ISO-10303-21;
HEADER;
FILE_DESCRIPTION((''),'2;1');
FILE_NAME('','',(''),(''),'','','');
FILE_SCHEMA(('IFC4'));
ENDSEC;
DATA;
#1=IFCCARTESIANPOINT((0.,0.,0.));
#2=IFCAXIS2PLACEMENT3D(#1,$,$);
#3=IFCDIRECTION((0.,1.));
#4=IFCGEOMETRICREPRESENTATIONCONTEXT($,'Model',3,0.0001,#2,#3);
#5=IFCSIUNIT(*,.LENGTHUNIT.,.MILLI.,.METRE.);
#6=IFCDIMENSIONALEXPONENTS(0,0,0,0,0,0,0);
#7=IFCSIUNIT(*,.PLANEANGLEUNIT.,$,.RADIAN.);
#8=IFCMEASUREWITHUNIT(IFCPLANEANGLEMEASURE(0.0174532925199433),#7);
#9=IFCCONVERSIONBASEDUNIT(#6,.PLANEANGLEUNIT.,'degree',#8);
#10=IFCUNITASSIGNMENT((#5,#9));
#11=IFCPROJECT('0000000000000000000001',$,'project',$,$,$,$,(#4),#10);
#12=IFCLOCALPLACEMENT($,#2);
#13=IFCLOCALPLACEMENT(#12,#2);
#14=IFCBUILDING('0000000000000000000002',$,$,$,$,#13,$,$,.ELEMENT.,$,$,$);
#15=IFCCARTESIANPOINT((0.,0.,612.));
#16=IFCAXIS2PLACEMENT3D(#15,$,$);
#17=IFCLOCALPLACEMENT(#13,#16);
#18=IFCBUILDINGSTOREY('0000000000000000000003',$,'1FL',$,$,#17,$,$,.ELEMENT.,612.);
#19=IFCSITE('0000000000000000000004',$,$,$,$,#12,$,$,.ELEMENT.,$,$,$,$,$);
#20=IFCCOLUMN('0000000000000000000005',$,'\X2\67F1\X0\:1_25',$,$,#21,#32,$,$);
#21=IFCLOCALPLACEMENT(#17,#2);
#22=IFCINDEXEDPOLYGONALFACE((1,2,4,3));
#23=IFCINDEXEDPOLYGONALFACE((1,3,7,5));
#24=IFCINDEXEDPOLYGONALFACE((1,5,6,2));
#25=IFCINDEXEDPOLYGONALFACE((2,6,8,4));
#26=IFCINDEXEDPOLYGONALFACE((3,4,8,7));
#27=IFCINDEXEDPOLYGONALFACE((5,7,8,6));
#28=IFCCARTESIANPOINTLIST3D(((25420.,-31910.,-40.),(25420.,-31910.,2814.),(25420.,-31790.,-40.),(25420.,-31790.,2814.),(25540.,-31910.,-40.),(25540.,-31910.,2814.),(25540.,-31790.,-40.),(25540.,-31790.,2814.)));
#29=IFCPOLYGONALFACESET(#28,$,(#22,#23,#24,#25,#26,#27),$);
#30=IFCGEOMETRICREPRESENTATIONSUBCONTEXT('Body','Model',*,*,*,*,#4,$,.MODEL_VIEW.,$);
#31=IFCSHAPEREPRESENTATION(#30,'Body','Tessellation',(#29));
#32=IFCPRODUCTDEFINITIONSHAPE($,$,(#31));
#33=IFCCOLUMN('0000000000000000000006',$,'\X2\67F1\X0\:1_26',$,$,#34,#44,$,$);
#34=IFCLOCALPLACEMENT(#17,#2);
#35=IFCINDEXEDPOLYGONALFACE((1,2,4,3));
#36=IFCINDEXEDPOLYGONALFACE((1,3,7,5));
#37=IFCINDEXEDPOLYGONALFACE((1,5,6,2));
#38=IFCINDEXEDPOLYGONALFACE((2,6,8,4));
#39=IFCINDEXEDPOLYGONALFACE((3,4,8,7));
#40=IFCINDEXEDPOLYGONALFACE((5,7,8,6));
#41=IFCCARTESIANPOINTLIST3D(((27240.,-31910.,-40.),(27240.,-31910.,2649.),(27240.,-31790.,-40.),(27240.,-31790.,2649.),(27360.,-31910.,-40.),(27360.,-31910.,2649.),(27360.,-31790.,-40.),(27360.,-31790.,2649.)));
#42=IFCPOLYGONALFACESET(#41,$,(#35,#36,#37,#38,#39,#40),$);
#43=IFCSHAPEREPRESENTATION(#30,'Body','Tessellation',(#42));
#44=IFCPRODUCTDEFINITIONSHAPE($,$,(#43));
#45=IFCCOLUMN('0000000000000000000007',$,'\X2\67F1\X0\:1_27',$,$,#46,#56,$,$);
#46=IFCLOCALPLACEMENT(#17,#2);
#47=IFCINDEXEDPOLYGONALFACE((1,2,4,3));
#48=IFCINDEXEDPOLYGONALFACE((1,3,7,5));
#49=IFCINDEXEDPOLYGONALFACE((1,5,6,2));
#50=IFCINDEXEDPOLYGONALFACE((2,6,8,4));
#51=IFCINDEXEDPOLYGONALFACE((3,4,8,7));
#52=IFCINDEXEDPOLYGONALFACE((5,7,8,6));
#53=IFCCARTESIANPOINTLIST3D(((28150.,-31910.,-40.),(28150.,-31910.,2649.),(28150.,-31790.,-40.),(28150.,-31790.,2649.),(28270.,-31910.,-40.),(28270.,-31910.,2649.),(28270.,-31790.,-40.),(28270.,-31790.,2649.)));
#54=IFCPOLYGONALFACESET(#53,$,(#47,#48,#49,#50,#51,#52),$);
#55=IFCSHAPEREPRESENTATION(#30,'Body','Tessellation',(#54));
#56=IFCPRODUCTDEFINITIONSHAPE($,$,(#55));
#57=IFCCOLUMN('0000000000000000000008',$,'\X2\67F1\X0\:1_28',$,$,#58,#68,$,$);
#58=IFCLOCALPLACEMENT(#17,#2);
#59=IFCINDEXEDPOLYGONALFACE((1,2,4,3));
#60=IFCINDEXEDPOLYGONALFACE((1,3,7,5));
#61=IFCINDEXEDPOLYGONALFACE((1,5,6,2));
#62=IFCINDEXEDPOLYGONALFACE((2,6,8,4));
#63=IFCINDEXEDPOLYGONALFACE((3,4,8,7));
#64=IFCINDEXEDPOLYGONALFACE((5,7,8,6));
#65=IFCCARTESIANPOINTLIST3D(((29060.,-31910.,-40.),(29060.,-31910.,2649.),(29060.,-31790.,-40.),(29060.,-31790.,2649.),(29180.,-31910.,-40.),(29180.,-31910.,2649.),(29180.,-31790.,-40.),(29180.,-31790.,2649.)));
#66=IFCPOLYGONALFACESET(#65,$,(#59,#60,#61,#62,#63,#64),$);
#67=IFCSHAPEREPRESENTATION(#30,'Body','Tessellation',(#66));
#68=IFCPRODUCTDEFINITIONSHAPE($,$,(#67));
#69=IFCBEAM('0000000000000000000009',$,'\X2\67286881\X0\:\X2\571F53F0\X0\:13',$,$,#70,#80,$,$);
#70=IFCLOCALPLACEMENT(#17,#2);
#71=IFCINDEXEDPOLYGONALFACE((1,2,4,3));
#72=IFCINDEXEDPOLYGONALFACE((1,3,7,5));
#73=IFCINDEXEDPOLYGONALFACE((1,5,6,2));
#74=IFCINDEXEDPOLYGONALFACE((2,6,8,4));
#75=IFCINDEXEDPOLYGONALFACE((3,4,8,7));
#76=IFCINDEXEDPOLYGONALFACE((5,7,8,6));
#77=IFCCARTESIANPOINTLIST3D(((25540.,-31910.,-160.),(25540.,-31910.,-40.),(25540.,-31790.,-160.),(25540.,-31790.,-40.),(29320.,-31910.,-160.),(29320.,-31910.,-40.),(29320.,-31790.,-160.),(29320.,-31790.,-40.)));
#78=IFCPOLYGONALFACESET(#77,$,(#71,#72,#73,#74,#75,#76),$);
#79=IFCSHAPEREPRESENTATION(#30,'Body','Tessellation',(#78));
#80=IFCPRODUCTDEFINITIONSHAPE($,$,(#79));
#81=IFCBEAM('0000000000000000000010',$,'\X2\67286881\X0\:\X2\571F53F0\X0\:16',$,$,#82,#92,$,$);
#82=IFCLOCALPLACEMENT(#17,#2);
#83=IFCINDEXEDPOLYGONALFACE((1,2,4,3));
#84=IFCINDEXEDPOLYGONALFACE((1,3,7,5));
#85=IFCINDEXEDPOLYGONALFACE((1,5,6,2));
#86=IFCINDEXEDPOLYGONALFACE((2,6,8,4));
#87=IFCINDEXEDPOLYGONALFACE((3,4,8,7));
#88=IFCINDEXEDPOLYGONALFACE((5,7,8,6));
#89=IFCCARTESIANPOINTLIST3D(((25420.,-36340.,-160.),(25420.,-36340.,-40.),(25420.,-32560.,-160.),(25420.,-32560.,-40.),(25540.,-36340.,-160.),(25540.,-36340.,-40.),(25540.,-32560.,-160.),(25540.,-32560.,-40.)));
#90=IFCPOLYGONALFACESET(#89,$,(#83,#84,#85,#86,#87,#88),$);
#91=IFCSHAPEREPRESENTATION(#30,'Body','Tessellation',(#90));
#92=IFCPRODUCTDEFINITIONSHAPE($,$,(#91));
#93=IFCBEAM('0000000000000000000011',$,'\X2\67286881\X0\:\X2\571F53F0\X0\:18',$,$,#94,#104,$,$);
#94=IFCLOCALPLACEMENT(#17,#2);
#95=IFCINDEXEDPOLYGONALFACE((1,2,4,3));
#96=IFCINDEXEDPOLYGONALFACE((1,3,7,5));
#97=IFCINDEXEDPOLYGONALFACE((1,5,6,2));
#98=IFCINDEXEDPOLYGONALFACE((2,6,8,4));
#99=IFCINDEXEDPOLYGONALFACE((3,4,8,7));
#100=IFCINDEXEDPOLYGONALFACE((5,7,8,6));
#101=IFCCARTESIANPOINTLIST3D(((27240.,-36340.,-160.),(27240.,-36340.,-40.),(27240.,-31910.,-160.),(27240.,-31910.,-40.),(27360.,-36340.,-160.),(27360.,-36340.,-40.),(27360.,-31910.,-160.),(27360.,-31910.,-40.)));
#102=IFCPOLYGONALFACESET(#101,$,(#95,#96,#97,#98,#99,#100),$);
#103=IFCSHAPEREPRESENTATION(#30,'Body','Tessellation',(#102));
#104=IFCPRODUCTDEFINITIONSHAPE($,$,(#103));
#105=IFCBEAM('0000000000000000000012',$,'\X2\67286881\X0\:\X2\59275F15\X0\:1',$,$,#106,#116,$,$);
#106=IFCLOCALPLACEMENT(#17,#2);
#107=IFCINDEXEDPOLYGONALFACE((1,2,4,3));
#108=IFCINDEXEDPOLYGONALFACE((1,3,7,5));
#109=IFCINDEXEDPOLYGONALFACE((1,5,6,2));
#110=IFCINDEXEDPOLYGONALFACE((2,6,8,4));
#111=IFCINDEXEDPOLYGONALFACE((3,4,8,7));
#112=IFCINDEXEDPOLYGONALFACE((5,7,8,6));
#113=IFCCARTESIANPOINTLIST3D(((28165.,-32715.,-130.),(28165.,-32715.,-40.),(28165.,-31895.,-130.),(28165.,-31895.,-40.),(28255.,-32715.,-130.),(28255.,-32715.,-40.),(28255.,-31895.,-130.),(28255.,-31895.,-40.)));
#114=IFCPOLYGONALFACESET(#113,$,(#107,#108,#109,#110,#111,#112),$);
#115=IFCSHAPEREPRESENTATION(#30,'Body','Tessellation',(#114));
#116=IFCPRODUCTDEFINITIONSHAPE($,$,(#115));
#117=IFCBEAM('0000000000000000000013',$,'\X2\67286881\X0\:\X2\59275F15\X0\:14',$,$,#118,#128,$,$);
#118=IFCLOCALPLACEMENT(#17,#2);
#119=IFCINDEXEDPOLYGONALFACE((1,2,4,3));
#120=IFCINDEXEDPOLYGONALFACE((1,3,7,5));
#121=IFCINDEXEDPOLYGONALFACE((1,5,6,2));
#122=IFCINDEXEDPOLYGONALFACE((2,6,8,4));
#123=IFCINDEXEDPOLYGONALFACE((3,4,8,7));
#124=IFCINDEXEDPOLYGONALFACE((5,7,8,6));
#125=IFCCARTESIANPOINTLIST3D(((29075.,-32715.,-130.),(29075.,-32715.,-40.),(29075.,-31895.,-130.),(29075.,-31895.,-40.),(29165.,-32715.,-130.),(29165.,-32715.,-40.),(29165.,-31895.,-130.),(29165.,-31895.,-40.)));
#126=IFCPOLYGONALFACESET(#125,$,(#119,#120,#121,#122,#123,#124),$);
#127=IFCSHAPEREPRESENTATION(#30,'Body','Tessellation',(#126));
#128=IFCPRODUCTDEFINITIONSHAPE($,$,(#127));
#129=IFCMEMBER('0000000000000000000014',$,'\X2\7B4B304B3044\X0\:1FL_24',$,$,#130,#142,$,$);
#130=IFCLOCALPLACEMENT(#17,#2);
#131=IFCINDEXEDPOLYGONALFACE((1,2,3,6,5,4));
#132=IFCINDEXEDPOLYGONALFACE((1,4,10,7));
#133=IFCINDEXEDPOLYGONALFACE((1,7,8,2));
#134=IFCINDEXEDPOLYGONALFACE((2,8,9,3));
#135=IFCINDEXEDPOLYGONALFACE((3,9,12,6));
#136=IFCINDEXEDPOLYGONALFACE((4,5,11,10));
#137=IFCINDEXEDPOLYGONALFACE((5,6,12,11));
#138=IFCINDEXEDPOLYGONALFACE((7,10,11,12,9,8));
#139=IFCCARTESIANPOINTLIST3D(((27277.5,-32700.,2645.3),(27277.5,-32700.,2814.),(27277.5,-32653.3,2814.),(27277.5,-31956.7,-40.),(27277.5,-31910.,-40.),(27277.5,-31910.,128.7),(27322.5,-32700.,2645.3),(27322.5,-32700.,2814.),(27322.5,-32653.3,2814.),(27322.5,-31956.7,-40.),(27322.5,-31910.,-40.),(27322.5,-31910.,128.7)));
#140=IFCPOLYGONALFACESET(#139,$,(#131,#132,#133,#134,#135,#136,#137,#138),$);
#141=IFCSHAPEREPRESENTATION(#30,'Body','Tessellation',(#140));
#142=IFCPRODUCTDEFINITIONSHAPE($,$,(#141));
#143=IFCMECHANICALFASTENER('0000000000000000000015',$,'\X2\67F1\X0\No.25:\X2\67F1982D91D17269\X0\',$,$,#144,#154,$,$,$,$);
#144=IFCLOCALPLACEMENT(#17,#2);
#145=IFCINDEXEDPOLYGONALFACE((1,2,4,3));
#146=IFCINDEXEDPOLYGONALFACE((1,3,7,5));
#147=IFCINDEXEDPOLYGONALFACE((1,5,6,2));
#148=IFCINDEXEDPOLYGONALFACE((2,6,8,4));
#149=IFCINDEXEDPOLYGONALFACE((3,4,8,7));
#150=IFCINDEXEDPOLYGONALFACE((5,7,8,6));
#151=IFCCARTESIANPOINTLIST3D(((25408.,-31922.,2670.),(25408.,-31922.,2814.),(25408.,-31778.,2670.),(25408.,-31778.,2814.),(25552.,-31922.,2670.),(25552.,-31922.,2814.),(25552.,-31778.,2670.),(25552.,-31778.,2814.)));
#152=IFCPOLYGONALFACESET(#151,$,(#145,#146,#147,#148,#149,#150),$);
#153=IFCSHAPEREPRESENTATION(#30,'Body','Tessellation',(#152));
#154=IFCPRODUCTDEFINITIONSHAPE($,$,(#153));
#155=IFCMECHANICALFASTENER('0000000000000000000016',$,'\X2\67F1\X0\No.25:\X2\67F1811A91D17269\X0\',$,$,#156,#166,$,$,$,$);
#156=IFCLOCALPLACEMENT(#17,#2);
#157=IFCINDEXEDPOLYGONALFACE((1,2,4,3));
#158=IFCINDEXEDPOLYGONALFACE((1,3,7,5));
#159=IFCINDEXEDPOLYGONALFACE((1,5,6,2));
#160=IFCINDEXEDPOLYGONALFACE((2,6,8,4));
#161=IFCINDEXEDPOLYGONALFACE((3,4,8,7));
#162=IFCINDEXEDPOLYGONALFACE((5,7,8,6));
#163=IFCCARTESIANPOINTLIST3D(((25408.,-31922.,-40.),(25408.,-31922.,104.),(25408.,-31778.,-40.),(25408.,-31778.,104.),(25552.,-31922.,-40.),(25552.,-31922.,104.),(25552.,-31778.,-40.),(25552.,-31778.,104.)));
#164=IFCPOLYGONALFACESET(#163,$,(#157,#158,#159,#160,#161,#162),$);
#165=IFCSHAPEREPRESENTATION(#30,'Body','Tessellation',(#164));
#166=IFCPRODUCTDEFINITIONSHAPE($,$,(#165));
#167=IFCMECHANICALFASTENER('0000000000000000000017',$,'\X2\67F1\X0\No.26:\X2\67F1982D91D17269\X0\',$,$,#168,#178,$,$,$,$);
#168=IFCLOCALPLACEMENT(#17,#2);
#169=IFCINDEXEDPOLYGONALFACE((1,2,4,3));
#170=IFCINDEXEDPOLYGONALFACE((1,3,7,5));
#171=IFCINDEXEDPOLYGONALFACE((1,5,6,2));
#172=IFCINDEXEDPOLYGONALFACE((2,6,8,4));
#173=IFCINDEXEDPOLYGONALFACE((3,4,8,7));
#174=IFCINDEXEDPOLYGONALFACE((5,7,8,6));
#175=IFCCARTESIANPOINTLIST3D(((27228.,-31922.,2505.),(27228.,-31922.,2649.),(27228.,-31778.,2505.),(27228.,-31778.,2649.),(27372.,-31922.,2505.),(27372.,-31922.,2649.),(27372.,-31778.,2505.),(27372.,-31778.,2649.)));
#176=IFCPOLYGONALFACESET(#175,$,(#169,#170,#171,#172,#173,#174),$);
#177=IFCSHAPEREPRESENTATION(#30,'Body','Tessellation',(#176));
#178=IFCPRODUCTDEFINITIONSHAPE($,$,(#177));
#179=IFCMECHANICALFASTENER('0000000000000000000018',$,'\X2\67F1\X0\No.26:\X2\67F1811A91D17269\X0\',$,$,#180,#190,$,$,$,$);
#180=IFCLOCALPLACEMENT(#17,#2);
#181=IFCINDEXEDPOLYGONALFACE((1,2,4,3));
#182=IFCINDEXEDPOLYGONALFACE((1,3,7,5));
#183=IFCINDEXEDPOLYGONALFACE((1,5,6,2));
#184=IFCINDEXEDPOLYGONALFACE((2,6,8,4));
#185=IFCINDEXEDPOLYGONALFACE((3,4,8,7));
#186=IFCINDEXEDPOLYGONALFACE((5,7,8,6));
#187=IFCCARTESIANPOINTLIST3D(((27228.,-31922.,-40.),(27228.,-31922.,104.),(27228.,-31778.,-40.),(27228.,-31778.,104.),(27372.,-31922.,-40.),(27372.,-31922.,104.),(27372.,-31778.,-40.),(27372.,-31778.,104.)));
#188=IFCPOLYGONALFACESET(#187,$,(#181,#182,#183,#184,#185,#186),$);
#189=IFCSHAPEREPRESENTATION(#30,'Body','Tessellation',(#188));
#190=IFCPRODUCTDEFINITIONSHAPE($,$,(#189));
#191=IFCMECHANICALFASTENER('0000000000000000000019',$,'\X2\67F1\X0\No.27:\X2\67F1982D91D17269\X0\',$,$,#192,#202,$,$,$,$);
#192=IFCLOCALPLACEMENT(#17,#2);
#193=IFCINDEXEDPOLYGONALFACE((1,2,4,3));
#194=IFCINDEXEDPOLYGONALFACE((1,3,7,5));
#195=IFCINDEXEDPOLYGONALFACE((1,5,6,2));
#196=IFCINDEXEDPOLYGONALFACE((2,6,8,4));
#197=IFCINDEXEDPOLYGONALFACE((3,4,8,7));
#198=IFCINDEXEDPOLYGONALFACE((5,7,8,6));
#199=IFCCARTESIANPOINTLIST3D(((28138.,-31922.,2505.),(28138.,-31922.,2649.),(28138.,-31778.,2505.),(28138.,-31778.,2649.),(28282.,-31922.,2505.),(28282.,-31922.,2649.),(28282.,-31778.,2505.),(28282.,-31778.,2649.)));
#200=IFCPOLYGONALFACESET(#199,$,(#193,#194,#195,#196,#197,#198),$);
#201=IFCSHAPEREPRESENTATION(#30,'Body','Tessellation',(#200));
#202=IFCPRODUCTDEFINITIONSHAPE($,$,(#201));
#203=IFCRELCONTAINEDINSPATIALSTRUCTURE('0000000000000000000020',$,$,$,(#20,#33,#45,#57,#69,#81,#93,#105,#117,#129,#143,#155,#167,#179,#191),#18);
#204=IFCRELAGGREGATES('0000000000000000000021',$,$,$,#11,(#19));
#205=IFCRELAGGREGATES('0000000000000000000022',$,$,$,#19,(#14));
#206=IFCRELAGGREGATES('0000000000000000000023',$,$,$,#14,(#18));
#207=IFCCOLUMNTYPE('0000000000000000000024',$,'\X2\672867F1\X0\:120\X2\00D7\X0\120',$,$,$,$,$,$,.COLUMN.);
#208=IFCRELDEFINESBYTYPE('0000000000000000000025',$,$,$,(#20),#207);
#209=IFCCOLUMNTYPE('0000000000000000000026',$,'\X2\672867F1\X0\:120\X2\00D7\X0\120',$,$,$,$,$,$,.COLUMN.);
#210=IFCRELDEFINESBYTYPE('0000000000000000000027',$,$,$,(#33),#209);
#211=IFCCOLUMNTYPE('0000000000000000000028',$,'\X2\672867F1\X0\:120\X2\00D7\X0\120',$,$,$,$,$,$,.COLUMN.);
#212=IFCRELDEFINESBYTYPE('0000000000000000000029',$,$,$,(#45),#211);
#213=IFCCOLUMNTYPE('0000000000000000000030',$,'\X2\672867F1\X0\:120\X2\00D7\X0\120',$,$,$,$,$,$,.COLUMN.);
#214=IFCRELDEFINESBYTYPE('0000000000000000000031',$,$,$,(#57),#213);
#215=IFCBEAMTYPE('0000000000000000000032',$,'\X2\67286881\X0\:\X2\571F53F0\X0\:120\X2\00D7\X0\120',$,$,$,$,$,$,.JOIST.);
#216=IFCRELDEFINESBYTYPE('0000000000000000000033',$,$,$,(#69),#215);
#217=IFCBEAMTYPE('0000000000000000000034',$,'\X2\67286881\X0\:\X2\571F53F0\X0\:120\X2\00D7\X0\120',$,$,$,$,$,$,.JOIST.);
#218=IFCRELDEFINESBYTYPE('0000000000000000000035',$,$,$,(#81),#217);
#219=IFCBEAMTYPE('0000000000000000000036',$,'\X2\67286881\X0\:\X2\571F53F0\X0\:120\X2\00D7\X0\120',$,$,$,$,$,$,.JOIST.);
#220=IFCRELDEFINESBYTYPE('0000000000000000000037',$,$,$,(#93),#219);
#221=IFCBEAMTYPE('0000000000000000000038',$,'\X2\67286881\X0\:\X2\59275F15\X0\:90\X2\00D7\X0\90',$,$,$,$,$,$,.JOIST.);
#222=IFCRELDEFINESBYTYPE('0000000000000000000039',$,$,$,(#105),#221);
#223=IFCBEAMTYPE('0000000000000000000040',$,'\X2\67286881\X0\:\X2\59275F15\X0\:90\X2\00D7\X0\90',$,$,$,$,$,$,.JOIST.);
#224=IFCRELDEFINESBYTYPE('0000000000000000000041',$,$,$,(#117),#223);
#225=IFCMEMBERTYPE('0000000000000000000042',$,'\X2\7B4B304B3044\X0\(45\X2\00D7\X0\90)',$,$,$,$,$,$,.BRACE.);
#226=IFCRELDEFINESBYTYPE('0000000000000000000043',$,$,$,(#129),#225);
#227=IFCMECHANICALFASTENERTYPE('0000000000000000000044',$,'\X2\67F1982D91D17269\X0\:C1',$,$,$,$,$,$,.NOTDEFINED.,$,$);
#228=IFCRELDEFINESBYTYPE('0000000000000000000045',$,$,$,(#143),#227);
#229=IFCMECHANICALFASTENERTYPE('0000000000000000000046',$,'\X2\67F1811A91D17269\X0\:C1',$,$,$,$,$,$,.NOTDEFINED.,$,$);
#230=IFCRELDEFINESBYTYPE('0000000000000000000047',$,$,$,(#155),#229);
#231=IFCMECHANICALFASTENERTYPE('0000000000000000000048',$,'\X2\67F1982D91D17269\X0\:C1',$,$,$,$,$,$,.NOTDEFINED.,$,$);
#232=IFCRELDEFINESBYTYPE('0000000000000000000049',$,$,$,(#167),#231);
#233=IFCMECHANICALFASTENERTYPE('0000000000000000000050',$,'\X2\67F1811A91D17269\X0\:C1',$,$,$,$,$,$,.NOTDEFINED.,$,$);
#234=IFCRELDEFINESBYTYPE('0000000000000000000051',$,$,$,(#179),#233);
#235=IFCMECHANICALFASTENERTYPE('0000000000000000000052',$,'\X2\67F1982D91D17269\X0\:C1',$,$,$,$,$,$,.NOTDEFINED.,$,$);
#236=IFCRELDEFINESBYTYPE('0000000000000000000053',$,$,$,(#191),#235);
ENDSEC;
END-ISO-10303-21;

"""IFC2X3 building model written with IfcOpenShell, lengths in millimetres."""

from ifc_helpers import new_model, entity, si_unit, converted_unit, direction, frame, origin, origin_with_axes, origin_2d, place, context, subcontext, project, spatial, polyline, rectangle, outline, extrude, type_object, element, save


model = new_model("IFC2X3")

# Units and contexts
model_context = context("Model", 3, precision=0.0001, world=origin(), true_north=direction((0.0, 1.0)))
body_context = subcontext(model_context, "Body", "Model", "MODEL_VIEW")
ifc_project = project(units=[si_unit("LENGTHUNIT", "METRE", prefix="MILLI"), converted_unit("PLANEANGLEUNIT", "degree", entity("IfcPlaneAngleMeasure", 0.0174532925199433), si_unit("PLANEANGLEUNIT", "RADIAN"), dimensions=[0, 0, 0, 0, 0, 0, 0])], contexts=[model_context])

# Site, building, storey
site_placement = place(None, origin())
site = spatial("IfcSite", under=ifc_project, at=site_placement, CompositionType="ELEMENT")
building_placement = place(site_placement, origin())
building = spatial("IfcBuilding", under=site, at=building_placement, CompositionType="ELEMENT")
storey_placement = place(building_placement, frame((0.0, 0.0, 612.0)))
storey = spatial("IfcBuildingStorey", under=building, at=storey_placement, Name="1FL", CompositionType="ELEMENT", Elevation=612.0)

# Columns
column_type_1 = type_object("IfcColumnType", Name="木柱:120×120", PredefinedType="COLUMN")
column_1_placement = place(storey_placement, frame((25480.0, -31850.0, -40.0)))
element("IfcColumn", 1, at=column_1_placement, inside=storey, type_object=column_type_1, Name="柱:1_25", context=body_context, shape_type="SweptSolid", body=[
    extrude(rectangle(XDim=120.0, YDim=120.0, at=origin_2d()), origin_with_axes(), (0.0, 0.0, 1.0), 2854.0),
])
column_type_2 = type_object("IfcColumnType", Name="木柱:120×120", PredefinedType="COLUMN")
column_2_placement = place(storey_placement, frame((27300.0, -31850.0, -40.0)))
element("IfcColumn", 2, at=column_2_placement, inside=storey, type_object=column_type_2, Name="柱:1_26", context=body_context, shape_type="SweptSolid", body=[
    extrude(rectangle(XDim=120.0, YDim=120.0, at=origin_2d()), origin_with_axes(), (0.0, 0.0, 1.0), 2689.0),
])
column_type_3 = type_object("IfcColumnType", Name="木柱:120×120", PredefinedType="COLUMN")
column_3_placement = place(storey_placement, frame((28210.0, -31850.0, -40.0)))
element("IfcColumn", 3, at=column_3_placement, inside=storey, type_object=column_type_3, Name="柱:1_27", context=body_context, shape_type="SweptSolid", body=[
    extrude(rectangle(XDim=120.0, YDim=120.0, at=origin_2d()), origin_with_axes(), (0.0, 0.0, 1.0), 2689.0),
])
column_type_4 = type_object("IfcColumnType", Name="木柱:120×120", PredefinedType="COLUMN")
column_4_placement = place(storey_placement, frame((29120.0, -31850.0, -40.0)))
element("IfcColumn", 4, at=column_4_placement, inside=storey, type_object=column_type_4, Name="柱:1_28", context=body_context, shape_type="SweptSolid", body=[
    extrude(rectangle(XDim=120.0, YDim=120.0, at=origin_2d()), origin_with_axes(), (0.0, 0.0, 1.0), 2689.0),
])

# Beams
beam_type_1 = type_object("IfcBeamType", Name="木梁:土台:120×120", PredefinedType="JOIST")
beam_1_placement = place(storey_placement, frame((25540.0, -31850.0, -100.0), z_axis=(1.0, 0.0, 0.0), x_axis=(0.0, 1.0, 0.0)))
element("IfcBeam", 5, at=beam_1_placement, inside=storey, type_object=beam_type_1, Name="木梁:土台:13", context=body_context, shape_type="SweptSolid", body=[
    extrude(rectangle(XDim=120.0, YDim=120.0, at=origin_2d()), origin_with_axes(), (0.0, 0.0, 1.0), 3780.0),
])
beam_type_2 = type_object("IfcBeamType", Name="木梁:土台:120×120", PredefinedType="JOIST")
beam_2_placement = place(storey_placement, frame((25480.0, -32560.0, -100.0), z_axis=(0.0, -1.0, 0.0), x_axis=(1.0, 0.0, 0.0)))
element("IfcBeam", 6, at=beam_2_placement, inside=storey, type_object=beam_type_2, Name="木梁:土台:16", context=body_context, shape_type="SweptSolid", body=[
    extrude(rectangle(XDim=120.0, YDim=120.0, at=origin_2d()), origin_with_axes(), (0.0, 0.0, 1.0), 3780.0),
])
beam_type_3 = type_object("IfcBeamType", Name="木梁:土台:120×120", PredefinedType="JOIST")
beam_3_placement = place(storey_placement, frame((27300.0, -31910.0, -100.0), z_axis=(0.0, -1.0, 0.0), x_axis=(1.0, 0.0, 0.0)))
element("IfcBeam", 7, at=beam_3_placement, inside=storey, type_object=beam_type_3, Name="木梁:土台:18", context=body_context, shape_type="SweptSolid", body=[
    extrude(rectangle(XDim=120.0, YDim=120.0, at=origin_2d()), origin_with_axes(), (0.0, 0.0, 1.0), 4430.0),
])
beam_type_4 = type_object("IfcBeamType", Name="木梁:大引:90×90", PredefinedType="JOIST")
beam_4_placement = place(storey_placement, frame((28210.0, -31895.0, -85.0), z_axis=(0.0, -1.0, 0.0), x_axis=(1.0, 0.0, 0.0)))
element("IfcBeam", 8, at=beam_4_placement, inside=storey, type_object=beam_type_4, Name="木梁:大引:1", context=body_context, shape_type="SweptSolid", body=[
    extrude(rectangle(XDim=90.0, YDim=90.0, at=origin_2d()), origin_with_axes(), (0.0, 0.0, 1.0), 820.0),
])
beam_type_5 = type_object("IfcBeamType", Name="木梁:大引:90×90", PredefinedType="JOIST")
beam_5_placement = place(storey_placement, frame((29120.0, -31895.0, -85.0), z_axis=(0.0, -1.0, 0.0), x_axis=(1.0, 0.0, 0.0)))
element("IfcBeam", 9, at=beam_5_placement, inside=storey, type_object=beam_type_5, Name="木梁:大引:14", context=body_context, shape_type="SweptSolid", body=[
    extrude(rectangle(XDim=90.0, YDim=90.0, at=origin_2d()), origin_with_axes(), (0.0, 0.0, 1.0), 820.0),
])

# Member
member_type_1 = type_object("IfcMemberType", Name="筋かい(45×90)", PredefinedType="BRACE")
member_1_placement = place(storey_placement, frame((27300.0, -31910.0, -40.0), z_axis=(0.0, -0.266773, 0.963759), x_axis=(0.0, 0.963759, 0.266773)))
element("IfcMember", 10, at=member_1_placement, inside=storey, type_object=member_type_1, Name="筋かい:1FL_24", context=body_context, shape_type="SweptSolid", body=[
    extrude(outline(polyline([(0.0, 0.0), (12.5, -45.0), (2798.8, -45.0), (2961.3, 0.0), (2948.9, 45.0), (162.6, 45.0), (0.0, 0.0)])), frame((0.0, -22.5, 0.0), z_axis=(0.0, 1.0, 0.0), x_axis=(0.0, 0.0, 1.0)), (0.0, 0.0, 1.0), 45.0),
])

# Mechanical fasteners
mechanical_fastener_type_1 = type_object("IfcMechanicalFastenerType", Name="柱頭金物:C1")
mechanical_fastener_1_placement = place(storey_placement, frame((25480.0, -31850.0, 2670.0)))
element("IfcMechanicalFastener", 11, at=mechanical_fastener_1_placement, inside=storey, type_object=mechanical_fastener_type_1, Name="柱No.25:柱頭金物", context=body_context, shape_type="SweptSolid", body=[
    extrude(rectangle(XDim=144.0, YDim=144.0, at=origin_2d()), origin_with_axes(), (0.0, 0.0, 1.0), 144.0),
])
mechanical_fastener_type_2 = type_object("IfcMechanicalFastenerType", Name="柱脚金物:C1")
mechanical_fastener_2_placement = place(storey_placement, frame((25480.0, -31850.0, -40.0)))
element("IfcMechanicalFastener", 12, at=mechanical_fastener_2_placement, inside=storey, type_object=mechanical_fastener_type_2, Name="柱No.25:柱脚金物", context=body_context, shape_type="SweptSolid", body=[
    extrude(rectangle(XDim=144.0, YDim=144.0, at=origin_2d()), origin_with_axes(), (0.0, 0.0, 1.0), 144.0),
])
mechanical_fastener_type_3 = type_object("IfcMechanicalFastenerType", Name="柱頭金物:C1")
mechanical_fastener_3_placement = place(storey_placement, frame((27300.0, -31850.0, 2505.0)))
element("IfcMechanicalFastener", 13, at=mechanical_fastener_3_placement, inside=storey, type_object=mechanical_fastener_type_3, Name="柱No.26:柱頭金物", context=body_context, shape_type="SweptSolid", body=[
    extrude(rectangle(XDim=144.0, YDim=144.0, at=origin_2d()), origin_with_axes(), (0.0, 0.0, 1.0), 144.0),
])
mechanical_fastener_type_4 = type_object("IfcMechanicalFastenerType", Name="柱脚金物:C1")
mechanical_fastener_4_placement = place(storey_placement, frame((27300.0, -31850.0, -40.0)))
element("IfcMechanicalFastener", 14, at=mechanical_fastener_4_placement, inside=storey, type_object=mechanical_fastener_type_4, Name="柱No.26:柱脚金物", context=body_context, shape_type="SweptSolid", body=[
    extrude(rectangle(XDim=144.0, YDim=144.0, at=origin_2d()), origin_with_axes(), (0.0, 0.0, 1.0), 144.0),
])
mechanical_fastener_type_5 = type_object("IfcMechanicalFastenerType", Name="柱頭金物:C1")
mechanical_fastener_5_placement = place(storey_placement, frame((28210.0, -31850.0, 2505.0)))
element("IfcMechanicalFastener", 15, at=mechanical_fastener_5_placement, inside=storey, type_object=mechanical_fastener_type_5, Name="柱No.27:柱頭金物", context=body_context, shape_type="SweptSolid", body=[
    extrude(rectangle(XDim=144.0, YDim=144.0, at=origin_2d()), origin_with_axes(), (0.0, 0.0, 1.0), 144.0),
])

save(model, "model.ifc")
